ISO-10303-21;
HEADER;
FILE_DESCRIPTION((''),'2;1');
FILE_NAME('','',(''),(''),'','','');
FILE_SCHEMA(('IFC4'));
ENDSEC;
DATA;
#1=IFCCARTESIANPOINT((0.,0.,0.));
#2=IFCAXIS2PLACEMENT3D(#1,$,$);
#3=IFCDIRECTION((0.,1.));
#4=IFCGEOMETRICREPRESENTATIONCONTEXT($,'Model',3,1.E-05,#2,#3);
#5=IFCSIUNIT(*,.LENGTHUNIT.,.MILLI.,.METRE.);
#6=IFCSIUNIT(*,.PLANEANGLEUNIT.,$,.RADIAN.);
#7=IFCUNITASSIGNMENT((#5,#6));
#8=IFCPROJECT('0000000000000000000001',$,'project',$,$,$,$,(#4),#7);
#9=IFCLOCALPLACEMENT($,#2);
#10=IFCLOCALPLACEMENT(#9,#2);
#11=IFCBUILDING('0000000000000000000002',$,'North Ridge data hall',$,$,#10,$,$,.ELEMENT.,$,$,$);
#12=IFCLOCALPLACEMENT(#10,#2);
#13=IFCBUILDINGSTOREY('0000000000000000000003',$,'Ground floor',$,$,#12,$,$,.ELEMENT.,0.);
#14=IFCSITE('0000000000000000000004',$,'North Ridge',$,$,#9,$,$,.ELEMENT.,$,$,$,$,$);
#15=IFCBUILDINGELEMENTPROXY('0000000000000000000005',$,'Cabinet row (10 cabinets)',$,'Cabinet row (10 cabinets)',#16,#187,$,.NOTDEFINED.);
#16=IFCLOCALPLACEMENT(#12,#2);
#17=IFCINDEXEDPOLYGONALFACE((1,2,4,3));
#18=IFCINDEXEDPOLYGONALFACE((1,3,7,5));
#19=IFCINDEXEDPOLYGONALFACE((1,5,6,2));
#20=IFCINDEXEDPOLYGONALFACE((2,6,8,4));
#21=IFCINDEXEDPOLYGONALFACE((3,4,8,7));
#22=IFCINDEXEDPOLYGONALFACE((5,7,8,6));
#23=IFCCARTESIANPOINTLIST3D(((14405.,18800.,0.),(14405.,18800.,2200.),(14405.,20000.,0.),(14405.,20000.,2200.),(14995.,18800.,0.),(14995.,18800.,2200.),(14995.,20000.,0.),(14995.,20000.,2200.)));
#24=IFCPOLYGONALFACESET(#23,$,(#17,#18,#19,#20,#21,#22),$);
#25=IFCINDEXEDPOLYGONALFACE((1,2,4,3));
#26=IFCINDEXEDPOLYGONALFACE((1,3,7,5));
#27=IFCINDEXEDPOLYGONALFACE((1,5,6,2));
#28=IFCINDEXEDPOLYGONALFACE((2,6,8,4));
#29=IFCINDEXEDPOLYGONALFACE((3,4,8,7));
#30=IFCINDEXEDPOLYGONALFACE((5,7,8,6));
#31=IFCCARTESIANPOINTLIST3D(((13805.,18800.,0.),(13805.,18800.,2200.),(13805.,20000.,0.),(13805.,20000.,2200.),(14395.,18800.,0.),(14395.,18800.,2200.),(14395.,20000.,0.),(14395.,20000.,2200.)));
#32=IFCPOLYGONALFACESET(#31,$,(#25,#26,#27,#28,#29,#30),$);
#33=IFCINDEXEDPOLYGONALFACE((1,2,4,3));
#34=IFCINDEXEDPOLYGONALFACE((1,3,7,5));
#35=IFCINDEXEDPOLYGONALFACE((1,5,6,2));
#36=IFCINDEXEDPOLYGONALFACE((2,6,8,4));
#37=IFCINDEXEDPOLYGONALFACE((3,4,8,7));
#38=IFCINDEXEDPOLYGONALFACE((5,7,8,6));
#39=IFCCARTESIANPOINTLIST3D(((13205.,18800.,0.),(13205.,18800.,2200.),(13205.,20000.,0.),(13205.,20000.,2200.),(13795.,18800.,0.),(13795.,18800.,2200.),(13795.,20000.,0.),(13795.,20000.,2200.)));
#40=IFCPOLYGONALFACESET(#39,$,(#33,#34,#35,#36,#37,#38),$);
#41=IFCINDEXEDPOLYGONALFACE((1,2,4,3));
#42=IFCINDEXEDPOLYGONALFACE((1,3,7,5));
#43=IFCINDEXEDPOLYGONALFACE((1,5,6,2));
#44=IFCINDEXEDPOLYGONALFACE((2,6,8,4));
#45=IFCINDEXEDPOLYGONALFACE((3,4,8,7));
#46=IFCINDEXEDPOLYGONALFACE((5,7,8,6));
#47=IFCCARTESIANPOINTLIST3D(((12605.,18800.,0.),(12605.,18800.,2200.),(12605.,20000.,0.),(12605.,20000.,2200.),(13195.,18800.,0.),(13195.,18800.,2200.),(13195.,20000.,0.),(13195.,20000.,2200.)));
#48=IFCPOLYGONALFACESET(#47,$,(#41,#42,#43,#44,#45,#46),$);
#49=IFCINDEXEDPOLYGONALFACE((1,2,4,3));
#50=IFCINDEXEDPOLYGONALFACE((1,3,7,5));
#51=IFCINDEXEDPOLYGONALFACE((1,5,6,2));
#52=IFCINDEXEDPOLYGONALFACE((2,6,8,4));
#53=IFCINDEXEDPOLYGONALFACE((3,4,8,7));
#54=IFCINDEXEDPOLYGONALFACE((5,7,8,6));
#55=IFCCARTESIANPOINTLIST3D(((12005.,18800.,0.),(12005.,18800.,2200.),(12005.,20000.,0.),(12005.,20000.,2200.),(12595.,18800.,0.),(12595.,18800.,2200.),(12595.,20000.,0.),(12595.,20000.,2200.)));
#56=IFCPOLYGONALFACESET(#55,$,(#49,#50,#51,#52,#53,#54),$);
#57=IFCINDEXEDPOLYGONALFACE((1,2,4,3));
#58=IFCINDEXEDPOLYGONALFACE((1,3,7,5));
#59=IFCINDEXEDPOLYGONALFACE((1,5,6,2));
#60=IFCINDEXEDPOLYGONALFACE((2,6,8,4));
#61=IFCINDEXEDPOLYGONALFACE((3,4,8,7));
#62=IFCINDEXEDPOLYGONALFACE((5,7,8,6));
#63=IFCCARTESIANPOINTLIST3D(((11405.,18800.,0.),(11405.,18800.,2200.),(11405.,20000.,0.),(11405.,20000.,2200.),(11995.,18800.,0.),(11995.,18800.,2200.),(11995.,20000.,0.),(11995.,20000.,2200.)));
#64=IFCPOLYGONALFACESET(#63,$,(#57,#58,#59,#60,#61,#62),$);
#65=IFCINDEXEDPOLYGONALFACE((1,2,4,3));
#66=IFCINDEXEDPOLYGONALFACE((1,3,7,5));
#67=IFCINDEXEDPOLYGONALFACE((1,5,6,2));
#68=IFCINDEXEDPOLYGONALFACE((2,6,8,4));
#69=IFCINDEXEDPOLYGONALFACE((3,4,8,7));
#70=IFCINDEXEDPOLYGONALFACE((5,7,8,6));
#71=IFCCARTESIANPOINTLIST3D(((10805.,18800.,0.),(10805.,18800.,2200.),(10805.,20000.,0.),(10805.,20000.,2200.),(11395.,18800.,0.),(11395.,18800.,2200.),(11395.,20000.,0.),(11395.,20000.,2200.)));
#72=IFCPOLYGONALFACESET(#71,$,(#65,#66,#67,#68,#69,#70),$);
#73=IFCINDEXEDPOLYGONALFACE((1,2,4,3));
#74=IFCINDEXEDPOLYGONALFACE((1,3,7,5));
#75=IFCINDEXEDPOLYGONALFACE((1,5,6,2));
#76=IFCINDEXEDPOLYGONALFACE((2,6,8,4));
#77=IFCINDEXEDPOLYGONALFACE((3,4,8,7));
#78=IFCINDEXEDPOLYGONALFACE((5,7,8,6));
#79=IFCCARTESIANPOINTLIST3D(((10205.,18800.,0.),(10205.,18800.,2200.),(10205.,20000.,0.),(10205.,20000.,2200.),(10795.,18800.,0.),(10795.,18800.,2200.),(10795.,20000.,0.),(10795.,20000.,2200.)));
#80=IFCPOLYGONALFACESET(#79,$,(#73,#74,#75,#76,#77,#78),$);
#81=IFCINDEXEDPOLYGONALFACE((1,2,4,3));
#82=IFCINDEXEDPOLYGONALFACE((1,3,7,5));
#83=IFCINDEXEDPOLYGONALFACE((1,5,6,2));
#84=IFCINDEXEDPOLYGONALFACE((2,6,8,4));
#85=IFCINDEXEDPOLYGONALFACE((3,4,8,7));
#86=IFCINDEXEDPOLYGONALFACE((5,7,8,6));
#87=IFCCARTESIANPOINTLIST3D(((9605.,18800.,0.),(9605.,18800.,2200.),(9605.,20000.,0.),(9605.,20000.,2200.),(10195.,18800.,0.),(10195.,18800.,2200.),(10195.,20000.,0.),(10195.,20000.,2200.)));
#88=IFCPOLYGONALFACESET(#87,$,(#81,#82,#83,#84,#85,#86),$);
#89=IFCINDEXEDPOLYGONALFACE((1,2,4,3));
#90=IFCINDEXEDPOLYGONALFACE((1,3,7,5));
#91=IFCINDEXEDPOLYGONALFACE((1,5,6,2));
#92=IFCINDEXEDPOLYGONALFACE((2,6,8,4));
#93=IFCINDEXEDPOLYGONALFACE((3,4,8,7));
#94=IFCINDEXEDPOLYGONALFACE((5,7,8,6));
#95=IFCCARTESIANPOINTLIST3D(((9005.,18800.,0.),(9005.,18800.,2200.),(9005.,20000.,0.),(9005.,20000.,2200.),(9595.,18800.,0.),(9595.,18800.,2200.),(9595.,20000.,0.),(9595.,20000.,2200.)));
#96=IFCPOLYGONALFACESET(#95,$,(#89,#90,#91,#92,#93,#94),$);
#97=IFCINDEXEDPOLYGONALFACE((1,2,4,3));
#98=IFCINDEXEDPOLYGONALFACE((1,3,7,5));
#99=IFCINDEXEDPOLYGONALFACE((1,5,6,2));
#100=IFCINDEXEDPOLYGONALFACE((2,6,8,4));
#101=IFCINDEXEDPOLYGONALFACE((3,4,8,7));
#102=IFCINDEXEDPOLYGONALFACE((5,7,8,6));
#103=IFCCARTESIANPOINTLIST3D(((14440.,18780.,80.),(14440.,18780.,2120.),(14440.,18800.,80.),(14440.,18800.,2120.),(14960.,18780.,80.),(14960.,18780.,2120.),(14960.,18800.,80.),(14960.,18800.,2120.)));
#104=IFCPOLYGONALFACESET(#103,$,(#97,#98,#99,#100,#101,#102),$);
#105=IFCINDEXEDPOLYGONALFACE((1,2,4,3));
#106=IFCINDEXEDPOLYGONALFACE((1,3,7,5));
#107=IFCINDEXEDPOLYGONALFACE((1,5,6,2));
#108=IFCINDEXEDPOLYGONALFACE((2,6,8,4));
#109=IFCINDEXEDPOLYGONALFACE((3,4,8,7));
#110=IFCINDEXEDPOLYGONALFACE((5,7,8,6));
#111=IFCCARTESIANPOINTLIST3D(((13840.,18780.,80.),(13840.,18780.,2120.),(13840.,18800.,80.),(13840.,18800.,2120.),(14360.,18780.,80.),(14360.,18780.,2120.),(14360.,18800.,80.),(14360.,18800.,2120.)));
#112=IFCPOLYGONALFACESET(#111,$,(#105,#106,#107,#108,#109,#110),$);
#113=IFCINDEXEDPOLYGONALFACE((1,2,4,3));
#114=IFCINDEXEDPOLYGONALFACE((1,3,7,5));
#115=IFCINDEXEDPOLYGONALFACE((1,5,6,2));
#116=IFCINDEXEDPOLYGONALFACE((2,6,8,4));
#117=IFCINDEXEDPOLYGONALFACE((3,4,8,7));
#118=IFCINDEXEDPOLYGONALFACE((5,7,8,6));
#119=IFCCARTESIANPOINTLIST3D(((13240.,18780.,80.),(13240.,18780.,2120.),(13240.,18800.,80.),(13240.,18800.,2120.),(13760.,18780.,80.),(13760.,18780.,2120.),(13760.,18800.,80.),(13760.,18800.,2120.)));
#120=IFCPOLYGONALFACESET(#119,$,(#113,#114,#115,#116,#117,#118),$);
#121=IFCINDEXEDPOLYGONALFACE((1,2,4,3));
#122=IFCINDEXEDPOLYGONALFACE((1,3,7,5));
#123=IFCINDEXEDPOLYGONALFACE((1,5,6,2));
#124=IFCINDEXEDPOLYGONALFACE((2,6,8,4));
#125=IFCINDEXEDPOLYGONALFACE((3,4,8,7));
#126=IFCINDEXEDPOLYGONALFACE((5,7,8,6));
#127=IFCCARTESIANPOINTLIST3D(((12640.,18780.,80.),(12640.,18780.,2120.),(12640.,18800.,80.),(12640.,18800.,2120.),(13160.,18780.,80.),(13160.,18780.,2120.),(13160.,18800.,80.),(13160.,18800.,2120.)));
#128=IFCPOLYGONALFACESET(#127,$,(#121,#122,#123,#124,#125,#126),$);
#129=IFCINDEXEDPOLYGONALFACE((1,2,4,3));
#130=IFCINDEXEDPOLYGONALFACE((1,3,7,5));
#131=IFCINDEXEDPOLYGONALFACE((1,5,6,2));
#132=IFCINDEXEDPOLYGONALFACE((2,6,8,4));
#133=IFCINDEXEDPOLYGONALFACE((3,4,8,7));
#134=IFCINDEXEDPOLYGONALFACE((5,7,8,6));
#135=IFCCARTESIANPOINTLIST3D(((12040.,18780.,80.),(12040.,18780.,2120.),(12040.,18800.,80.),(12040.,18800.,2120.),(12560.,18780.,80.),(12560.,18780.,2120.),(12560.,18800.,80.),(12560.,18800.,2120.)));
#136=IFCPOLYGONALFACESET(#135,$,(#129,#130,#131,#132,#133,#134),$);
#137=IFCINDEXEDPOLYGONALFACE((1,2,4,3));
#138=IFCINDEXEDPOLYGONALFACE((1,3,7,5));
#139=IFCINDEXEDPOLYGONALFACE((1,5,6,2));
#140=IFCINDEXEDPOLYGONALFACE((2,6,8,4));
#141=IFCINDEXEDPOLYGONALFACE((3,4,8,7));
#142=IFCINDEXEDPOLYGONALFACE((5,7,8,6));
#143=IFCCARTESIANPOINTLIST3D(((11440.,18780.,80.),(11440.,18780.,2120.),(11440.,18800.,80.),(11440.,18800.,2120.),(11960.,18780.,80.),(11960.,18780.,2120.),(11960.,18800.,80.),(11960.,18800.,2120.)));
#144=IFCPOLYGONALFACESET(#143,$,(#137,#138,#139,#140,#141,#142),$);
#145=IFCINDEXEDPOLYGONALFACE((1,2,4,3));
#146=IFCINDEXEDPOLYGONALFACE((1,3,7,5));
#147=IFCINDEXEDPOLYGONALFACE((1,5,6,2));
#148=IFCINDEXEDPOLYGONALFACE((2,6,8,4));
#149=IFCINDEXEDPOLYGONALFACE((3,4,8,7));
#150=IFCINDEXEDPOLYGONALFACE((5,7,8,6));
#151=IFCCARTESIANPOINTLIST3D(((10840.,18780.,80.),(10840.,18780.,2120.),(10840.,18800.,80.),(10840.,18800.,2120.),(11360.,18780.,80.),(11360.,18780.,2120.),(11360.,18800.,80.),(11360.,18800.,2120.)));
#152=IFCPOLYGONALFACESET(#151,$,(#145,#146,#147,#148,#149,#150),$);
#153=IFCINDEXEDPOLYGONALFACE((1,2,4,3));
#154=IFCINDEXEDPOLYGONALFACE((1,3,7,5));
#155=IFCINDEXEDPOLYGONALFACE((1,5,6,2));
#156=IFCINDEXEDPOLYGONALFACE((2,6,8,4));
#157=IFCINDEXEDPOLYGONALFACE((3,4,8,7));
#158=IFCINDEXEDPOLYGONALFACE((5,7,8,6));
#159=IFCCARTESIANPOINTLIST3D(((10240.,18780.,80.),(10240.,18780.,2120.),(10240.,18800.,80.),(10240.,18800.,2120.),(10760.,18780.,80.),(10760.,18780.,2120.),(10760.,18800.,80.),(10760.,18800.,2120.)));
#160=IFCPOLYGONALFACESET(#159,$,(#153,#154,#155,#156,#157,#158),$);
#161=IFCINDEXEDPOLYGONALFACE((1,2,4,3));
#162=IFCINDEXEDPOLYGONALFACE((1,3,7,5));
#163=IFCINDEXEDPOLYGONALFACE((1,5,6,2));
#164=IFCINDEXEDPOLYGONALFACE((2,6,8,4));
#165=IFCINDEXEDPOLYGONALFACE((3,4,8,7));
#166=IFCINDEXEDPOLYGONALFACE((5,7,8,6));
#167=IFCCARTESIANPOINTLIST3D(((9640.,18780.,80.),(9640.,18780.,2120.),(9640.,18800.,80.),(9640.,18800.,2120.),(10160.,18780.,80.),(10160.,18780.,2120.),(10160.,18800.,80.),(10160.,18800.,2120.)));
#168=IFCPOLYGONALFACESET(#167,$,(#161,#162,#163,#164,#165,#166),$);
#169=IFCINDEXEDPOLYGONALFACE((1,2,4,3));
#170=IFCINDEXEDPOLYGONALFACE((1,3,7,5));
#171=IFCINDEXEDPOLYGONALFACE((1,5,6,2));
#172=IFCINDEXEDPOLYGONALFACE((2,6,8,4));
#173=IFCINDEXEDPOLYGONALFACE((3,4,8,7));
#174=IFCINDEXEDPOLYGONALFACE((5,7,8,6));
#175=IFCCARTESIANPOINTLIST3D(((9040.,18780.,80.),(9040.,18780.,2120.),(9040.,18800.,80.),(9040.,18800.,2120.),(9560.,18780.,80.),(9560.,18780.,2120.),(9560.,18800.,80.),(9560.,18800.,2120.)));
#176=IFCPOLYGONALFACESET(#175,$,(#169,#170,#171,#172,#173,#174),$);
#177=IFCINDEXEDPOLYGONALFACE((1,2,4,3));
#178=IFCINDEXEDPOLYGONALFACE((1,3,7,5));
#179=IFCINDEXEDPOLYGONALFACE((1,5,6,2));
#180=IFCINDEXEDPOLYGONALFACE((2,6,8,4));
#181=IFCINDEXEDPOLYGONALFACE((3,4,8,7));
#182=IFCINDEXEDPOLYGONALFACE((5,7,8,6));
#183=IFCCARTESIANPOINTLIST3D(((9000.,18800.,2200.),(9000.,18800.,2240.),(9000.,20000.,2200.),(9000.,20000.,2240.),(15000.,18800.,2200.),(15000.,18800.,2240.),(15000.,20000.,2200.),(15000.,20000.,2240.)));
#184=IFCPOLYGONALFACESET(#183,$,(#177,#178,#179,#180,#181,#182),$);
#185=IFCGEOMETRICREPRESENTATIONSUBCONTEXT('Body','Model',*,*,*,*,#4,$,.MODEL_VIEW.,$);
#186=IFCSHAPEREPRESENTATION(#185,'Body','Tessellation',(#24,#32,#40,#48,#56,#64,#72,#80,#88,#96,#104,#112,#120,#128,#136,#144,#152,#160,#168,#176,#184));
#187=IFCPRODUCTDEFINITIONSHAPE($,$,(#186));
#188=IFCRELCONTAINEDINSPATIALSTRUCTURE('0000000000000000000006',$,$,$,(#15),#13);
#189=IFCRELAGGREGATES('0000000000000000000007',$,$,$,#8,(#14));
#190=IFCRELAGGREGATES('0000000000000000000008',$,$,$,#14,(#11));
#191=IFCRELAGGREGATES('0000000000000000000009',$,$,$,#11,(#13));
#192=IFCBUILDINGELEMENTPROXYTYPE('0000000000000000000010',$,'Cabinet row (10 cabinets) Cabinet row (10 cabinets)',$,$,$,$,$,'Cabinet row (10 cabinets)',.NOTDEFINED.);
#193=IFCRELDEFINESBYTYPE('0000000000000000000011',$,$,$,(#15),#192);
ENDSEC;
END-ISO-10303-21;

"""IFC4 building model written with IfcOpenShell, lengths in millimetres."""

from ifc_helpers import new_model, si_unit, direction, frame, origin, place, context, subcontext, project, spatial, polyline, outline, extrude, source, transform, mapped, type_object, type_shapes, element, save


model = new_model("IFC4")

# Units and contexts
model_context = context("Model", 3, precision=1e-05, world=origin(), true_north=direction((0.0, 1.0)))
body_context = subcontext(model_context, "Body", "Model", "MODEL_VIEW")
ifc_project = project(units=[si_unit("LENGTHUNIT", "METRE", prefix="MILLI"), si_unit("PLANEANGLEUNIT", "RADIAN")], contexts=[model_context])

# Site, building, storey
site_placement = place(None, origin())
site = spatial("IfcSite", under=ifc_project, at=site_placement, Name="North Ridge", CompositionType="ELEMENT")
building_placement = place(site_placement, origin())
building = spatial("IfcBuilding", under=site, at=building_placement, Name="North Ridge data hall", CompositionType="ELEMENT")
storey_placement = place(building_placement, origin())
storey = spatial("IfcBuildingStorey", under=building, at=storey_placement, Name="Ground floor", CompositionType="ELEMENT", Elevation=0.0)

# Building element proxy
building_element_proxy_type_1 = type_object("IfcBuildingElementProxyType", Name="Cabinet row (10 cabinets) Cabinet row (10 cabinets)", ElementType="Cabinet row (10 cabinets)", PredefinedType="NOTDEFINED")
shared_shape_1 = source(origin(), body_context, "Body", "SweptSolid", [
    extrude(outline(polyline([(5.0, 0.0), (595.0, 0.0), (595.0, 1200.0), (5.0, 1200.0), (5.0, 0.0)])), origin(), (0.0, 0.0, 1.0), 2200.0),
    extrude(outline(polyline([(605.0, 0.0), (1195.0, 0.0), (1195.0, 1200.0), (605.0, 1200.0), (605.0, 0.0)])), origin(), (0.0, 0.0, 1.0), 2200.0),
    extrude(outline(polyline([(1205.0, 0.0), (1795.0, 0.0), (1795.0, 1200.0), (1205.0, 1200.0), (1205.0, 0.0)])), origin(), (0.0, 0.0, 1.0), 2200.0),
    extrude(outline(polyline([(1805.0, 0.0), (2395.0, 0.0), (2395.0, 1200.0), (1805.0, 1200.0), (1805.0, 0.0)])), origin(), (0.0, 0.0, 1.0), 2200.0),
    extrude(outline(polyline([(2405.0, 0.0), (2995.0, 0.0), (2995.0, 1200.0), (2405.0, 1200.0), (2405.0, 0.0)])), origin(), (0.0, 0.0, 1.0), 2200.0),
    extrude(outline(polyline([(3005.0, 0.0), (3595.0, 0.0), (3595.0, 1200.0), (3005.0, 1200.0), (3005.0, 0.0)])), origin(), (0.0, 0.0, 1.0), 2200.0),
    extrude(outline(polyline([(3605.0, 0.0), (4195.0, 0.0), (4195.0, 1200.0), (3605.0, 1200.0), (3605.0, 0.0)])), origin(), (0.0, 0.0, 1.0), 2200.0),
    extrude(outline(polyline([(4205.0, 0.0), (4795.0, 0.0), (4795.0, 1200.0), (4205.0, 1200.0), (4205.0, 0.0)])), origin(), (0.0, 0.0, 1.0), 2200.0),
    extrude(outline(polyline([(4805.0, 0.0), (5395.0, 0.0), (5395.0, 1200.0), (4805.0, 1200.0), (4805.0, 0.0)])), origin(), (0.0, 0.0, 1.0), 2200.0),
    extrude(outline(polyline([(5405.0, 0.0), (5995.0, 0.0), (5995.0, 1200.0), (5405.0, 1200.0), (5405.0, 0.0)])), origin(), (0.0, 0.0, 1.0), 2200.0),
    extrude(outline(polyline([(40.0, 1200.0), (560.0, 1200.0), (560.0, 1220.0), (40.0, 1220.0), (40.0, 1200.0)])), frame((0.0, 0.0, 80.0)), (0.0, 0.0, 1.0), 2040.0),
    extrude(outline(polyline([(640.0, 1200.0), (1160.0, 1200.0), (1160.0, 1220.0), (640.0, 1220.0), (640.0, 1200.0)])), frame((0.0, 0.0, 80.0)), (0.0, 0.0, 1.0), 2040.0),
    extrude(outline(polyline([(1240.0, 1200.0), (1760.0, 1200.0), (1760.0, 1220.0), (1240.0, 1220.0), (1240.0, 1200.0)])), frame((0.0, 0.0, 80.0)), (0.0, 0.0, 1.0), 2040.0),
    extrude(outline(polyline([(1840.0, 1200.0), (2360.0, 1200.0), (2360.0, 1220.0), (1840.0, 1220.0), (1840.0, 1200.0)])), frame((0.0, 0.0, 80.0)), (0.0, 0.0, 1.0), 2040.0),
    extrude(outline(polyline([(2440.0, 1200.0), (2960.0, 1200.0), (2960.0, 1220.0), (2440.0, 1220.0), (2440.0, 1200.0)])), frame((0.0, 0.0, 80.0)), (0.0, 0.0, 1.0), 2040.0),
    extrude(outline(polyline([(3040.0, 1200.0), (3560.0, 1200.0), (3560.0, 1220.0), (3040.0, 1220.0), (3040.0, 1200.0)])), frame((0.0, 0.0, 80.0)), (0.0, 0.0, 1.0), 2040.0),
    extrude(outline(polyline([(3640.0, 1200.0), (4160.0, 1200.0), (4160.0, 1220.0), (3640.0, 1220.0), (3640.0, 1200.0)])), frame((0.0, 0.0, 80.0)), (0.0, 0.0, 1.0), 2040.0),
    extrude(outline(polyline([(4240.0, 1200.0), (4760.0, 1200.0), (4760.0, 1220.0), (4240.0, 1220.0), (4240.0, 1200.0)])), frame((0.0, 0.0, 80.0)), (0.0, 0.0, 1.0), 2040.0),
    extrude(outline(polyline([(4840.0, 1200.0), (5360.0, 1200.0), (5360.0, 1220.0), (4840.0, 1220.0), (4840.0, 1200.0)])), frame((0.0, 0.0, 80.0)), (0.0, 0.0, 1.0), 2040.0),
    extrude(outline(polyline([(5440.0, 1200.0), (5960.0, 1200.0), (5960.0, 1220.0), (5440.0, 1220.0), (5440.0, 1200.0)])), frame((0.0, 0.0, 80.0)), (0.0, 0.0, 1.0), 2040.0),
    extrude(outline(polyline([(0.0, 0.0), (6000.0, 0.0), (6000.0, 1200.0), (0.0, 1200.0), (0.0, 0.0)])), frame((0.0, 0.0, 2200.0)), (0.0, 0.0, 1.0), 40.0),
])
type_shapes(building_element_proxy_type_1, [shared_shape_1])
for number, where, z_axis, x_axis, name in (
    (1, (15000.0, 20000.0, 0.0), (0.0, 0.0, 1.0), (-1.0, 0.0, 0.0), "Cabinet row (10 cabinets)"),
):
    element("IfcBuildingElementProxy", number, at=place(storey_placement, frame(where, z_axis=z_axis, x_axis=x_axis)), inside=storey, type_object=building_element_proxy_type_1, Name=name, ObjectType="Cabinet row (10 cabinets)", PredefinedType="NOTDEFINED", context=body_context, shape_type="MappedRepresentation", body=[
        mapped(shared_shape_1, transform((0.0, 0.0, 0.0))),
    ])

save(model, "model.ifc")
